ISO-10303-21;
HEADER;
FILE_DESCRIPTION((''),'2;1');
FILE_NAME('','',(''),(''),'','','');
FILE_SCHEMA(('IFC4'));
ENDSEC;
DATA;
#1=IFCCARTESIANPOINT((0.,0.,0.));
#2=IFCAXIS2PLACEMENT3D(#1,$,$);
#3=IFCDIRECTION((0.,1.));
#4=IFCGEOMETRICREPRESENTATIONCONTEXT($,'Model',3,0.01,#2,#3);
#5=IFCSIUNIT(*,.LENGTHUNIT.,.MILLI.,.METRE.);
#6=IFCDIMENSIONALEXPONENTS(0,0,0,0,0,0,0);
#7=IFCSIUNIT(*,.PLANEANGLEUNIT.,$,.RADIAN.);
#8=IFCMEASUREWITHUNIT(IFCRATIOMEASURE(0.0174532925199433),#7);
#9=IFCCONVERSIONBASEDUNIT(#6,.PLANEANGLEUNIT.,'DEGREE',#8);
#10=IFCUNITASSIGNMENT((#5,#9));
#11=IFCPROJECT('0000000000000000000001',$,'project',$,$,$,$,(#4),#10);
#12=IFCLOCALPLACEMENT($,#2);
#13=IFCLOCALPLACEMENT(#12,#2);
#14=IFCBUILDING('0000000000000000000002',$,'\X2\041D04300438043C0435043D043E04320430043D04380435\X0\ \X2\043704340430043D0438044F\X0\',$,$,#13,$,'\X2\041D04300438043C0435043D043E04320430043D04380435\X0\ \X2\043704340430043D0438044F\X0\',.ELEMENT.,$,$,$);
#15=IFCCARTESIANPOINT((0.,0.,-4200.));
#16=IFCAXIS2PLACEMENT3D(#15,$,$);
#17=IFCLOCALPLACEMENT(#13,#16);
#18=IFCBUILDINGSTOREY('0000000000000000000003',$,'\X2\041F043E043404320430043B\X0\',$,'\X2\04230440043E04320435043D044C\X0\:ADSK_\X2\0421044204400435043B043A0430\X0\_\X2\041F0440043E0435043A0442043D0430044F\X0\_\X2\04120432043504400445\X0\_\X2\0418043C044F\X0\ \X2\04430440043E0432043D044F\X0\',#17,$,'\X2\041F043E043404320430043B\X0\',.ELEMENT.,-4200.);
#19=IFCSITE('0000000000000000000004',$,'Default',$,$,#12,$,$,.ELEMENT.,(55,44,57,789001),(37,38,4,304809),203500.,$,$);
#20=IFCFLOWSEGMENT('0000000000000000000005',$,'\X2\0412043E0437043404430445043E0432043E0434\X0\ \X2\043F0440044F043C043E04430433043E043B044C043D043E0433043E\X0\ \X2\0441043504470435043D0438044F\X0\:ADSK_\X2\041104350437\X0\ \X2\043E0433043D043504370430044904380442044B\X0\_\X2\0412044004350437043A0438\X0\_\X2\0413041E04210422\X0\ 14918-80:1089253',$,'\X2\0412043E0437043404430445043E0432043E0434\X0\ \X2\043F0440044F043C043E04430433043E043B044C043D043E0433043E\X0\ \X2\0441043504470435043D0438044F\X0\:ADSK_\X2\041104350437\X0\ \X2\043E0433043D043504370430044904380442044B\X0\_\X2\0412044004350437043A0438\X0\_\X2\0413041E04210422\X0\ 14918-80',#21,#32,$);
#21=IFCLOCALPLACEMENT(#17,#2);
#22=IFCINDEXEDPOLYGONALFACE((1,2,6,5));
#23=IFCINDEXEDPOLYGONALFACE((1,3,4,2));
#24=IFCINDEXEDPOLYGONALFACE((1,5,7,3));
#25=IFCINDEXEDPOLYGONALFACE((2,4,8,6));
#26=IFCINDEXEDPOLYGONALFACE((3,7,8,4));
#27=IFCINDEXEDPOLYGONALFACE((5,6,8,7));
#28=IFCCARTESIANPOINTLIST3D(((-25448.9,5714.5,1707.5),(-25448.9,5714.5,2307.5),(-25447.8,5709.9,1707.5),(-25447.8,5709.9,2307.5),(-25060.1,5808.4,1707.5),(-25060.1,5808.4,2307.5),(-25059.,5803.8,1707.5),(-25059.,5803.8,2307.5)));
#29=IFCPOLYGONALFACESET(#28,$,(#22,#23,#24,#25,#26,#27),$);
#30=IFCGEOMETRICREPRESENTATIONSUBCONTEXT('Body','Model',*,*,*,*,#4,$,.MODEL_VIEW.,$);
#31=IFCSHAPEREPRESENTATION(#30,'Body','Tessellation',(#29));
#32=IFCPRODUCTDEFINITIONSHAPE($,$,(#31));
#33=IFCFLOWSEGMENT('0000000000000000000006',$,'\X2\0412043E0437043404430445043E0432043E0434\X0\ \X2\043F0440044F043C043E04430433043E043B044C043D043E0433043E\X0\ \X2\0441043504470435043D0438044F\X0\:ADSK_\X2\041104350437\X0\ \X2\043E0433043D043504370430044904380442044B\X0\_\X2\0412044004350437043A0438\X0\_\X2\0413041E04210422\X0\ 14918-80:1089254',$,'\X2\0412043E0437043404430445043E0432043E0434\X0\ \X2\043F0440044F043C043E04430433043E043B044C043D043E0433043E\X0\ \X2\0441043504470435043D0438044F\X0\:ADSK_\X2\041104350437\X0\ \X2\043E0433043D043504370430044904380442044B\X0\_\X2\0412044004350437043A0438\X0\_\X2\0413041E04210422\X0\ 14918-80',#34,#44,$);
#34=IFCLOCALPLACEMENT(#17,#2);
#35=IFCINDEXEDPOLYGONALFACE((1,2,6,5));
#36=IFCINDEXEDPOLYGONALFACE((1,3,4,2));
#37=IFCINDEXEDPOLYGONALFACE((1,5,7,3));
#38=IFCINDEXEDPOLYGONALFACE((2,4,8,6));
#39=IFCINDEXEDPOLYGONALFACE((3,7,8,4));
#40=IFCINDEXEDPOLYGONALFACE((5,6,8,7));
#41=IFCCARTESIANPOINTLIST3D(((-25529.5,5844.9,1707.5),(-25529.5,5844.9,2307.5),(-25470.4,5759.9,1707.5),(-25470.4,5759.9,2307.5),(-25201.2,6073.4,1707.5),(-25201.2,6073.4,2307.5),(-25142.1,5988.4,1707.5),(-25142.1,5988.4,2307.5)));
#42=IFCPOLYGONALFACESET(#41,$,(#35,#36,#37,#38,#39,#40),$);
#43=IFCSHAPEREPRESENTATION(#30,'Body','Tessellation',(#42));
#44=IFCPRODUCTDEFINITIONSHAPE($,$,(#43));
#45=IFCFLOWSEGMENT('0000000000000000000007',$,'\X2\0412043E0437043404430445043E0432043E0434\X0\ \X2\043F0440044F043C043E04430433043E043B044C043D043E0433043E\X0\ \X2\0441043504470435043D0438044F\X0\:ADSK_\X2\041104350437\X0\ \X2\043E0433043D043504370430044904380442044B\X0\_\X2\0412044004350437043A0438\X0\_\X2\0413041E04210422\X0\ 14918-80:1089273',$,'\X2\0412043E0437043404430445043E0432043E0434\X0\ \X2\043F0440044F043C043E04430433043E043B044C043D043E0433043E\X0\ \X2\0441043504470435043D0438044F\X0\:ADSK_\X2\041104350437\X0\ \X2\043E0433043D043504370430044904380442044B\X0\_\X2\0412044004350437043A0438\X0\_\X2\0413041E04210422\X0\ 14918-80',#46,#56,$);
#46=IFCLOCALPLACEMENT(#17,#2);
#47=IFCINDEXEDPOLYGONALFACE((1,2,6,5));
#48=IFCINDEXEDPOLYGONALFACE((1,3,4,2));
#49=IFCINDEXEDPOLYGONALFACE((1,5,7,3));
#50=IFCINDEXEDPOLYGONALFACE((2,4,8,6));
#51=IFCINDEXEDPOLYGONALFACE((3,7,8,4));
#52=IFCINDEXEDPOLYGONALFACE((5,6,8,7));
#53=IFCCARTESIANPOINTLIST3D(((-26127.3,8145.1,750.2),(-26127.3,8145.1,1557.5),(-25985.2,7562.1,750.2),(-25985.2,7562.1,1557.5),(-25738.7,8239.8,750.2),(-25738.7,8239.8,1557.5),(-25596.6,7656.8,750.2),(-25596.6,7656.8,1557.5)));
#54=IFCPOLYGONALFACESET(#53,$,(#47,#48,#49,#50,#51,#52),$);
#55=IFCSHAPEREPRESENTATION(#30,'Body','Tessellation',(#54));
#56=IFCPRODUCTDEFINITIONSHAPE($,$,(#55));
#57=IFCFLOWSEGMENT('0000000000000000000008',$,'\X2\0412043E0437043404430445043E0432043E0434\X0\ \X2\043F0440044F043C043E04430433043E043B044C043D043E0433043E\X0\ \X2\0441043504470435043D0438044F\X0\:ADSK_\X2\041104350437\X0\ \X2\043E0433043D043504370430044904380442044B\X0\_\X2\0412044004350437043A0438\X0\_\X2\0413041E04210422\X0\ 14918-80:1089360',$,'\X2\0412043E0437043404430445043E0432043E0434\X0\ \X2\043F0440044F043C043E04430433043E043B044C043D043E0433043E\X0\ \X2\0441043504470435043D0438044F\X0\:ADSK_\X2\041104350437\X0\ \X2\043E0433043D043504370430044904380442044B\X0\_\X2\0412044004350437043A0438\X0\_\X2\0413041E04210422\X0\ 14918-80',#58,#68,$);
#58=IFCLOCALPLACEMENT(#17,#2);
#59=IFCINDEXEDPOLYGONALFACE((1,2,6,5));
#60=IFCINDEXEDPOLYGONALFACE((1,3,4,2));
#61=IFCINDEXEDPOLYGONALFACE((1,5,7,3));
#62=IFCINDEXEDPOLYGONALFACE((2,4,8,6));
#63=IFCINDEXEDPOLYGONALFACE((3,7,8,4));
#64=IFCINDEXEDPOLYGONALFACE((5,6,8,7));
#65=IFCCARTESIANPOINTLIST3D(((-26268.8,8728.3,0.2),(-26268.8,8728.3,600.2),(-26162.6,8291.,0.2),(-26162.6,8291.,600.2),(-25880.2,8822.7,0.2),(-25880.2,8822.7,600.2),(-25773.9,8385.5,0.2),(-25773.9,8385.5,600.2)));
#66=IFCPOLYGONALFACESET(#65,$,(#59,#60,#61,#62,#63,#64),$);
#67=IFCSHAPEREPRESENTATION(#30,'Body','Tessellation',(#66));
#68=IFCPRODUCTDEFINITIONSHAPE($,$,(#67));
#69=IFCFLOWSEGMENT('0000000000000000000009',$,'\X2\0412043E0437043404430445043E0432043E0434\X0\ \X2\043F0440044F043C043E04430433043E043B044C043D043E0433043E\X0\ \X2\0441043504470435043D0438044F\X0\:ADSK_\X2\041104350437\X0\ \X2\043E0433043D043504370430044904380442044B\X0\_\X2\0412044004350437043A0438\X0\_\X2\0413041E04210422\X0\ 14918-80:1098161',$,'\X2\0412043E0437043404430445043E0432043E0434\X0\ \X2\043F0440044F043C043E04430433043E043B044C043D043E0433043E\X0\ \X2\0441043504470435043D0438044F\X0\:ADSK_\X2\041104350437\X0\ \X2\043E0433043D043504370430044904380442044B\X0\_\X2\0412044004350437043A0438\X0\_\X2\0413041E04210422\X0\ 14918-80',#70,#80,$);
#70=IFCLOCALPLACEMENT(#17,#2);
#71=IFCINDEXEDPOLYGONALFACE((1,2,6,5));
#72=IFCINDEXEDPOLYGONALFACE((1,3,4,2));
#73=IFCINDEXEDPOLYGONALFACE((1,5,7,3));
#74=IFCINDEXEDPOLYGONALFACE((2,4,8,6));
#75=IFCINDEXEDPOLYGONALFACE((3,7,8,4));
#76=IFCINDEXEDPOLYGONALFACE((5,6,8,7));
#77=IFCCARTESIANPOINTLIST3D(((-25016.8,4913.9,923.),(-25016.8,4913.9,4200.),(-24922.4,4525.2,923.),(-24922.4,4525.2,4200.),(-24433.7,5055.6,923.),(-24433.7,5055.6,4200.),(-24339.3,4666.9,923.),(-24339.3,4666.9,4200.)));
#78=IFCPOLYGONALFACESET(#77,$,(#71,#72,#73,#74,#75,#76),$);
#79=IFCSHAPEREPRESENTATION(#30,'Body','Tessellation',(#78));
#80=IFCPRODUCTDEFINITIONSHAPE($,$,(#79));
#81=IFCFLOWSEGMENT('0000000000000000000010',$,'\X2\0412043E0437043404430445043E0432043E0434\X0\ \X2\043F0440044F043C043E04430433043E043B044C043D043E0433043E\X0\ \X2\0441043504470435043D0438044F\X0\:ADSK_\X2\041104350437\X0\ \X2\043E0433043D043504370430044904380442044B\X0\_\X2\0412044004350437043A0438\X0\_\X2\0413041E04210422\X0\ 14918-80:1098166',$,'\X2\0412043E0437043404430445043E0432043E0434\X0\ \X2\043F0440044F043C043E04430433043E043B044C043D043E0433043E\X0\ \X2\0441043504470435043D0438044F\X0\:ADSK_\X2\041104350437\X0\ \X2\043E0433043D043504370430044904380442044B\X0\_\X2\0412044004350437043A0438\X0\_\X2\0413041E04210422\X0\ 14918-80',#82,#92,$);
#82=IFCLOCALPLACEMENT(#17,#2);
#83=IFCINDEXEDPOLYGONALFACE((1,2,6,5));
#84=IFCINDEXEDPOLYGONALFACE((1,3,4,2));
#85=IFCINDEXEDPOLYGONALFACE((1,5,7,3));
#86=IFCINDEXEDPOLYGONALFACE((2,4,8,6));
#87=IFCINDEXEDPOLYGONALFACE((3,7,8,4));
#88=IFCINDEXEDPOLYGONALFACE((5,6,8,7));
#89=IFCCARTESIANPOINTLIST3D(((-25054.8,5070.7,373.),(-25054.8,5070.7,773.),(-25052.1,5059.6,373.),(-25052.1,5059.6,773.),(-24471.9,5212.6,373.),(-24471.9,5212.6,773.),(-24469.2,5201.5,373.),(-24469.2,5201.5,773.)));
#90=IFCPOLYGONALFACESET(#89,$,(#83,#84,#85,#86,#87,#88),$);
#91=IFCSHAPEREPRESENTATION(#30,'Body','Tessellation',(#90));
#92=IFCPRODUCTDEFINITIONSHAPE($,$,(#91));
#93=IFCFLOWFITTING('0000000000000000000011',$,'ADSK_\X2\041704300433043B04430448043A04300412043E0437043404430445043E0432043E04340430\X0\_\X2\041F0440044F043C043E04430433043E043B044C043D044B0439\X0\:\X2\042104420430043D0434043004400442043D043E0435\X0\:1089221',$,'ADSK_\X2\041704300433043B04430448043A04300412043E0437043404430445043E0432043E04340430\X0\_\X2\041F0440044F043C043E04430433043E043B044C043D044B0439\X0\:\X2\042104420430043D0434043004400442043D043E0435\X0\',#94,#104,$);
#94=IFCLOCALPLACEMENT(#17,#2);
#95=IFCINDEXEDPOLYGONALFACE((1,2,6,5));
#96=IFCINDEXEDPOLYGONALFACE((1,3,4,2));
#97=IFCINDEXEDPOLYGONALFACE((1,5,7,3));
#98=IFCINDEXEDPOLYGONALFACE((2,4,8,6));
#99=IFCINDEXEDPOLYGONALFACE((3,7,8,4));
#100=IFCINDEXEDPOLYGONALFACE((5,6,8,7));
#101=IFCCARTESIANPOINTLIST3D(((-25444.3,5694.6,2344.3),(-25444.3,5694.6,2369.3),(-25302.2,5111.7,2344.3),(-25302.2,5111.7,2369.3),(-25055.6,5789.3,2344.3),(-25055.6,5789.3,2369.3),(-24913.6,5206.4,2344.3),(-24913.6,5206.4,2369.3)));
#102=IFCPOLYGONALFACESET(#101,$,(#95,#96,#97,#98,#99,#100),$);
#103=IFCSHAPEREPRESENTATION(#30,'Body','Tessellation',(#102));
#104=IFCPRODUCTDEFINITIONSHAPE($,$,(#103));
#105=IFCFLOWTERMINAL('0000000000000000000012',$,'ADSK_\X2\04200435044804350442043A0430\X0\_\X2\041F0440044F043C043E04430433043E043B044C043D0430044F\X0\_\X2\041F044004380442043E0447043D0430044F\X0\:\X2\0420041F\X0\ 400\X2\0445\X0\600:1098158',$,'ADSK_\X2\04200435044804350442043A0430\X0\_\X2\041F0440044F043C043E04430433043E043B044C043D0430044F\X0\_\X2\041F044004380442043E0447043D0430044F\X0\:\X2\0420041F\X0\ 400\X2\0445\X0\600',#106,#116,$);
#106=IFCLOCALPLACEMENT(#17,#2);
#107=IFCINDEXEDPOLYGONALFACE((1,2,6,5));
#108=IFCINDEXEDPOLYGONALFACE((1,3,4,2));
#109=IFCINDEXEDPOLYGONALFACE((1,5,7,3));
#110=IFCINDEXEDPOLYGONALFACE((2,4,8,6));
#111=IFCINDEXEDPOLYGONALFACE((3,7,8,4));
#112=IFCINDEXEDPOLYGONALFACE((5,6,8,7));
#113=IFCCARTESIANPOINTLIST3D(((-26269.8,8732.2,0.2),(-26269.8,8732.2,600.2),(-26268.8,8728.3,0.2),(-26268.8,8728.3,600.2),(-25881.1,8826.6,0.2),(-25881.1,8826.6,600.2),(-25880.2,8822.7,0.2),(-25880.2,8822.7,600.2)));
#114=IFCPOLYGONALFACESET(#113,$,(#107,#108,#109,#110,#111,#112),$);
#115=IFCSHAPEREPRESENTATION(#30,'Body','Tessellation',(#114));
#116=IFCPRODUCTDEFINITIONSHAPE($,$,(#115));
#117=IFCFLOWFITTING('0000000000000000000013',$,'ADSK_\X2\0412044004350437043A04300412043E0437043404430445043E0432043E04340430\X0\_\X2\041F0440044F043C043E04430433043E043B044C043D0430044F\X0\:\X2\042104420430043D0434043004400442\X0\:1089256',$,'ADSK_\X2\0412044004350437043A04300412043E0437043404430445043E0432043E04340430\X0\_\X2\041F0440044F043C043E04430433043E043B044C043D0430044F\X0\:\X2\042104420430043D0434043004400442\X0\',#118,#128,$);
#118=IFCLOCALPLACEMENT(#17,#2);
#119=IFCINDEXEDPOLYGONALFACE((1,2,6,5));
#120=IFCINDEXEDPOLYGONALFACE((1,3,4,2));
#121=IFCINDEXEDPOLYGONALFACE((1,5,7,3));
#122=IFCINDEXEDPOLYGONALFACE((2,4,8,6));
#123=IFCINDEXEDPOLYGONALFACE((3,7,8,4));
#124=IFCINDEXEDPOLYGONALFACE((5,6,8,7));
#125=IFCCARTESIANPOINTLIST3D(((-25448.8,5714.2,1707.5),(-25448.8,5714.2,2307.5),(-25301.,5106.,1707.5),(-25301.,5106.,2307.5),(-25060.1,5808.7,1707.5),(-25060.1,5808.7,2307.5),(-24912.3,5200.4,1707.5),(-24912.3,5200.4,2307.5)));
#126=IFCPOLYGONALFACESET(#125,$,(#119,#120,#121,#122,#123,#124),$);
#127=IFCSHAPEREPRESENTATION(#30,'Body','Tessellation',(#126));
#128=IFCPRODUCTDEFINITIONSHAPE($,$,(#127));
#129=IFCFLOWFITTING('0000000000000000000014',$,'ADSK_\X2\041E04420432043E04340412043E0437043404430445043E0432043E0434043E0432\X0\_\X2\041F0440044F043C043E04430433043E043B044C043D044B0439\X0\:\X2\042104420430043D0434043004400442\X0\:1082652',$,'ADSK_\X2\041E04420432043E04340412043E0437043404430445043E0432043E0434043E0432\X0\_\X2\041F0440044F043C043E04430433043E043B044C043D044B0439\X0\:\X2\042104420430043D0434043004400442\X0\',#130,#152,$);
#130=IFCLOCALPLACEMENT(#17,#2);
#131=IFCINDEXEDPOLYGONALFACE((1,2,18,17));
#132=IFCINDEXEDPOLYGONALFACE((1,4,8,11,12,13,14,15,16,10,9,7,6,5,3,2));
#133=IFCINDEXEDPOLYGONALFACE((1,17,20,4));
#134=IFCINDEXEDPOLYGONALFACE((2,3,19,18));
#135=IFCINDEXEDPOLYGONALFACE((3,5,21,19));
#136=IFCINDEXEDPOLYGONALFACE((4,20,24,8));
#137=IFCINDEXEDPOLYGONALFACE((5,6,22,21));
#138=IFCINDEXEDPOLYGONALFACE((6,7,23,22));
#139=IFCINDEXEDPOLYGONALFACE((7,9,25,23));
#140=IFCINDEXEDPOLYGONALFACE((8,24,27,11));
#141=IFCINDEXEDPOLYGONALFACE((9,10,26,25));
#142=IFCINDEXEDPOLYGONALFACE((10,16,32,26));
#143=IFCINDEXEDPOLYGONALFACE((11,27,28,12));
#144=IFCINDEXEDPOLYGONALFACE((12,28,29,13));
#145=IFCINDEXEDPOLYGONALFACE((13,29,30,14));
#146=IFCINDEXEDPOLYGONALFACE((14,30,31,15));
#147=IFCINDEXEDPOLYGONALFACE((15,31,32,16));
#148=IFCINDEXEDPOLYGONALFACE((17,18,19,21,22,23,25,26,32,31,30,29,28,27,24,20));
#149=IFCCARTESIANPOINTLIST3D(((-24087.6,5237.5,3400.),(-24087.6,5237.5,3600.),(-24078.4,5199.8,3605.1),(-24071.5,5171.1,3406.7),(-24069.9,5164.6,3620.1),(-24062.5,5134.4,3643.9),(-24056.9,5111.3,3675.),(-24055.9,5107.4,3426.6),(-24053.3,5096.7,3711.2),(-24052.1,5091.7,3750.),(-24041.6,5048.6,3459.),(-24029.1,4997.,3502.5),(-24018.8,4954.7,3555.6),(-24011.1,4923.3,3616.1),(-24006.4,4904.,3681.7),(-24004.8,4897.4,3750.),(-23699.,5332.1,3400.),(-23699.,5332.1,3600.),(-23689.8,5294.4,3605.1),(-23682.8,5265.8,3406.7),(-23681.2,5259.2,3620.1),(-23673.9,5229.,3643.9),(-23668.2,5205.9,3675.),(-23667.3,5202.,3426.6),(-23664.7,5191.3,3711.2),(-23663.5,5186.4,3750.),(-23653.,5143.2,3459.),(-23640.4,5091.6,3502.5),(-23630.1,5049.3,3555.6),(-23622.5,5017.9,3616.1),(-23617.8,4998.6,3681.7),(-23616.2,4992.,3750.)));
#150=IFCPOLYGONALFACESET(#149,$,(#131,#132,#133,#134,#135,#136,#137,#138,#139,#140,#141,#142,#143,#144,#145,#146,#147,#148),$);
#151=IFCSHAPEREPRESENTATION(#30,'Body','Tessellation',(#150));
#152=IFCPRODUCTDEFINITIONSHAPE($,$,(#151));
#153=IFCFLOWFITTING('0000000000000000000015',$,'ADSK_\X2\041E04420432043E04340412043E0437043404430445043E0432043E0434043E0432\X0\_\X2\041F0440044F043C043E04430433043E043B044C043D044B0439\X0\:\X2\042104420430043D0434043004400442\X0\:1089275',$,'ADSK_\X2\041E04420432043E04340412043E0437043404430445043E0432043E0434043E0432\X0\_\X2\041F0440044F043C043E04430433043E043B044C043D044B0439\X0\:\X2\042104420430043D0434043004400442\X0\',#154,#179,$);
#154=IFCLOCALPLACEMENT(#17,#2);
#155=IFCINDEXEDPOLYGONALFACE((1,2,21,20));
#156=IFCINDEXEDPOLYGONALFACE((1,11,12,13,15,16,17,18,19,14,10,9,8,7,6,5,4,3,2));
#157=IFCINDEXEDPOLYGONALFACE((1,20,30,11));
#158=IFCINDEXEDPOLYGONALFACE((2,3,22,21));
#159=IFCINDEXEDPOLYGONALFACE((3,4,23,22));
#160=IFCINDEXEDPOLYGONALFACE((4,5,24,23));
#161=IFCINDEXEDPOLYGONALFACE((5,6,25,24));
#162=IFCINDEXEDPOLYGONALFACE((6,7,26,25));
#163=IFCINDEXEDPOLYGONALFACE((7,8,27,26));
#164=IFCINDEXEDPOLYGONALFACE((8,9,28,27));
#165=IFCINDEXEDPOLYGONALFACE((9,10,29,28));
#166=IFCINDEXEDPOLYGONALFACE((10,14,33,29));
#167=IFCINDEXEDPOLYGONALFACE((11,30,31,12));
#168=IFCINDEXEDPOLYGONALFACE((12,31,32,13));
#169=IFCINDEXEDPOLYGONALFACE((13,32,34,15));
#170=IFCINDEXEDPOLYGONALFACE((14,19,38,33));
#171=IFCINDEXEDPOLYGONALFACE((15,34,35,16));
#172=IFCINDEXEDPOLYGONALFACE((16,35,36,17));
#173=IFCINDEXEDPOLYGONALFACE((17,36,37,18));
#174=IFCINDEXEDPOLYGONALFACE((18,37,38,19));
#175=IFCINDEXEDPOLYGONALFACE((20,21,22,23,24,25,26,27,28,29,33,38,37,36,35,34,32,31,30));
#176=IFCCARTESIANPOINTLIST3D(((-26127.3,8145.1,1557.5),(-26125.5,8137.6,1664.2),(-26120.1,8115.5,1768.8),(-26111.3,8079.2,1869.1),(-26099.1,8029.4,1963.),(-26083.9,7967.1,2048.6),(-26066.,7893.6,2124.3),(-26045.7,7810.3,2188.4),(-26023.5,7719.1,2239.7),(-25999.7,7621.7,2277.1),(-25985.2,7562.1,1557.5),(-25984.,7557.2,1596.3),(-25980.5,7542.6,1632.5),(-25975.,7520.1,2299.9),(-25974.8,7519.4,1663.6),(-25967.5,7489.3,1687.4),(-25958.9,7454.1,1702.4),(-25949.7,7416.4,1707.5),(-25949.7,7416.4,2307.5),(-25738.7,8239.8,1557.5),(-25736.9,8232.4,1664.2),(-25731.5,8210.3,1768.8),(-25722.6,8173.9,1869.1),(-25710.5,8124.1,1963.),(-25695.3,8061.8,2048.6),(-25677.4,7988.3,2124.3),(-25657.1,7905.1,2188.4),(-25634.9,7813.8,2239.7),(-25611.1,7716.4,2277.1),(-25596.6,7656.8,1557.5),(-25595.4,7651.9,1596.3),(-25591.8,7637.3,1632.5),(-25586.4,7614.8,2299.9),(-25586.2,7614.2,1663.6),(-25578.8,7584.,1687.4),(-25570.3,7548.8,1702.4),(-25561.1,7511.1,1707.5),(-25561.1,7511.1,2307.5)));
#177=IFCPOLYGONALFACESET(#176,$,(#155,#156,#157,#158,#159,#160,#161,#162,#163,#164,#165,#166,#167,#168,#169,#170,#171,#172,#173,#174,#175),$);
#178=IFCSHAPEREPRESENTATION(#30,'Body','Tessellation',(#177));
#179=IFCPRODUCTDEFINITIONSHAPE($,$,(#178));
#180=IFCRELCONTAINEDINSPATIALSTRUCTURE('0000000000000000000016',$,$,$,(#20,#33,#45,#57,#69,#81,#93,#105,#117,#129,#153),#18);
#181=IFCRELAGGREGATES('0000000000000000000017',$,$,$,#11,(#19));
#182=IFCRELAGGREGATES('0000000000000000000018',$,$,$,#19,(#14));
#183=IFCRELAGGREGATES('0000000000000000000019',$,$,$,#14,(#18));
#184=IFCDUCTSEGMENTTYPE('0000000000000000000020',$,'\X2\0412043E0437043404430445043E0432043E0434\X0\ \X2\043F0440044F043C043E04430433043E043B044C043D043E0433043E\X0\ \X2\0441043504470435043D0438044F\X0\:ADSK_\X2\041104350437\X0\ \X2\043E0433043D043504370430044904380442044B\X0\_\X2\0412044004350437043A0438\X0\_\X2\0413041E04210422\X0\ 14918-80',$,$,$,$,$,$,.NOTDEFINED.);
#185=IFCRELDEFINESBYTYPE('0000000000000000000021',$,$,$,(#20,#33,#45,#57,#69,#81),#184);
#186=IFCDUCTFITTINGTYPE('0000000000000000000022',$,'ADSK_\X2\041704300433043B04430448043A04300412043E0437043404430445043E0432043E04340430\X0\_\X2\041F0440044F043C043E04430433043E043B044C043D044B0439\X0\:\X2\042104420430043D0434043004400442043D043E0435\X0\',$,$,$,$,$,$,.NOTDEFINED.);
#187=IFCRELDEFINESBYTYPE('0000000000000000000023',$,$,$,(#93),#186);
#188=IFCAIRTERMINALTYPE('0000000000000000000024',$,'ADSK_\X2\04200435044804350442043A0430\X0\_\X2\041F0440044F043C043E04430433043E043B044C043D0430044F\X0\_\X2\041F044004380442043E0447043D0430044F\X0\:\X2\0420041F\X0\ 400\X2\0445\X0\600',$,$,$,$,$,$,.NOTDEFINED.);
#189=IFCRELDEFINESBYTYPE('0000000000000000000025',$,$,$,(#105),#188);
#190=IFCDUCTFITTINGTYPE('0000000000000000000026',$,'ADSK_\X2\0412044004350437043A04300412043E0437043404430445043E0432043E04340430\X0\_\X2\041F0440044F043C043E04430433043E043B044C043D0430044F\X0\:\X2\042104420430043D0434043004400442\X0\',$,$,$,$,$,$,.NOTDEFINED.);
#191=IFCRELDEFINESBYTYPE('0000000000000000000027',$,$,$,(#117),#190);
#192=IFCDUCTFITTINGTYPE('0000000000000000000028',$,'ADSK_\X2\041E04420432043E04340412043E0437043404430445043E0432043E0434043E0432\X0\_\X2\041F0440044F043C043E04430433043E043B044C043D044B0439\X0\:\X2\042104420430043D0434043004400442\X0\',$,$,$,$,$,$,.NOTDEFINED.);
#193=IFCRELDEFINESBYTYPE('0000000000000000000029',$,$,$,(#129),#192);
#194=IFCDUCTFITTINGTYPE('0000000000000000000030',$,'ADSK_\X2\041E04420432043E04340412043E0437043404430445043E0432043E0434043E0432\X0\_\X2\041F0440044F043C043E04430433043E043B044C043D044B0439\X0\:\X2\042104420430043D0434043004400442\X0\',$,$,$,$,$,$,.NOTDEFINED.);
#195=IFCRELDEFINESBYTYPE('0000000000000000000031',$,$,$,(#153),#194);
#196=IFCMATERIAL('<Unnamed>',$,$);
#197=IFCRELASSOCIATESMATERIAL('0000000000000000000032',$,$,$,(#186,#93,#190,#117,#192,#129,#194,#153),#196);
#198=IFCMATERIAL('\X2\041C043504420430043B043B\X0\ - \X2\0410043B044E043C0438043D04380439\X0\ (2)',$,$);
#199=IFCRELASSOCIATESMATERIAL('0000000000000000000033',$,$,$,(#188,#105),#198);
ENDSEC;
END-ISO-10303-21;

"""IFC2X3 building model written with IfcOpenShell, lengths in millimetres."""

from ifc_helpers import new_model, entity, si_unit, converted_unit, direction, frame, frame_2d, origin, origin_2d_with_axis, place, context, subcontext, project, spatial, polyline, circle_curve, parameter, trimmed, segment, composite_curve, rectangle, outline, extrude, source, transform, mapped, material, type_object, type_shapes, element, save


model = new_model("IFC2X3")

# Units and contexts
model_context = context("Model", 3, precision=0.01, world=origin(), true_north=direction((0.0, 1.0)))
body_context = subcontext(model_context, "Body", "Model", "MODEL_VIEW")
ifc_project = project(units=[si_unit("LENGTHUNIT", "METRE", prefix="MILLI"), converted_unit("PLANEANGLEUNIT", "DEGREE", entity("IfcRatioMeasure", 0.0174532925199433), si_unit("PLANEANGLEUNIT", "RADIAN"), dimensions=[0, 0, 0, 0, 0, 0, 0])], contexts=[model_context])

# Site, building, storey
site_placement = place(None, origin())
site = spatial("IfcSite", under=ifc_project, at=site_placement, Name="Default", CompositionType="ELEMENT", RefLatitude=(55, 44, 57, 789001), RefLongitude=(37, 38, 4, 304809), RefElevation=203500.0)
building_placement = place(site_placement, origin())
building = spatial("IfcBuilding", under=site, at=building_placement, Name="Наименование здания", LongName="Наименование здания", CompositionType="ELEMENT")
storey_placement = place(building_placement, frame((0.0, 0.0, -4200.0)))
storey = spatial("IfcBuildingStorey", under=building, at=storey_placement, Name="Подвал", ObjectType="Уровень:ADSK_Стрелка_Проектная_Вверх_Имя уровня", LongName="Подвал", CompositionType="ELEMENT", Elevation=-4200.0)

# Flow segments
duct_segment_type_1 = type_object("IfcDuctSegmentType", Name="Воздуховод прямоугольного сечения:ADSK_Без огнезащиты_Врезки_ГОСТ 14918-80", PredefinedType="NOTDEFINED")
flow_segment_1_placement = place(storey_placement, frame((-25448.9, 5709.9, 1707.5)))
element("IfcFlowSegment", 1, at=flow_segment_1_placement, inside=storey, type_object=duct_segment_type_1, Name="Воздуховод прямоугольного сечения:ADSK_Без огнезащиты_Врезки_ГОСТ 14918-80:1089253", ObjectType="Воздуховод прямоугольного сечения:ADSK_Без огнезащиты_Врезки_ГОСТ 14918-80", context=body_context, shape_type="SweptSolid", body=[
    extrude(rectangle(XDim=4.8, YDim=400.0, at=origin_2d_with_axis()), frame((195.0, 49.3, 0.0), z_axis=(0.0, 0.0, 1.0), x_axis=(0.234768, -0.972051, 0.0)), (0.0, 0.0, 1.0), 600.0),
])
flow_segment_2_placement = place(storey_placement, frame((-25529.5, 5759.9, 1707.5)))
element("IfcFlowSegment", 2, at=flow_segment_2_placement, inside=storey, type_object=duct_segment_type_1, Name="Воздуховод прямоугольного сечения:ADSK_Без огнезащиты_Врезки_ГОСТ 14918-80:1089254", ObjectType="Воздуховод прямоугольного сечения:ADSK_Без огнезащиты_Врезки_ГОСТ 14918-80", context=body_context, shape_type="SweptSolid", body=[
    extrude(rectangle(XDim=103.6, YDim=400.0, at=origin_2d_with_axis()), frame((193.7, 156.8, 0.0), z_axis=(0.0, 0.0, 1.0), x_axis=(-0.571319, 0.820728, 0.0)), (0.0, 0.0, 1.0), 600.0),
])
flow_segment_3_placement = place(storey_placement, frame((-26127.3, 7562.1, 750.2)))
element("IfcFlowSegment", 3, at=flow_segment_3_placement, inside=storey, type_object=duct_segment_type_1, Name="Воздуховод прямоугольного сечения:ADSK_Без огнезащиты_Врезки_ГОСТ 14918-80:1089273", ObjectType="Воздуховод прямоугольного сечения:ADSK_Без огнезащиты_Врезки_ГОСТ 14918-80", context=body_context, shape_type="SweptSolid", body=[
    extrude(rectangle(XDim=400.0, YDim=600.0, at=origin_2d_with_axis()), frame((265.4, 338.8, 0.0), z_axis=(0.0, 0.0, 1.0), x_axis=(-0.971553, -0.236821, 0.0)), (0.0, 0.0, 1.0), 807.3),
])
flow_segment_4_placement = place(storey_placement, frame((-26268.8, 8291.0, 0.2)))
element("IfcFlowSegment", 4, at=flow_segment_4_placement, inside=storey, type_object=duct_segment_type_1, Name="Воздуховод прямоугольного сечения:ADSK_Без огнезащиты_Врезки_ГОСТ 14918-80:1089360", ObjectType="Воздуховод прямоугольного сечения:ADSK_Без огнезащиты_Врезки_ГОСТ 14918-80", context=body_context, shape_type="SweptSolid", body=[
    extrude(rectangle(XDim=450.0, YDim=400.0, at=origin_2d_with_axis()), frame((247.5, 265.9, 0.0), z_axis=(0.0, 0.0, 1.0), x_axis=(-0.23616, 0.971714, 0.0)), (0.0, 0.0, 1.0), 600.0),
])
flow_segment_5_placement = place(storey_placement, frame((-25016.8, 4525.2, 923.0)))
element("IfcFlowSegment", 5, at=flow_segment_5_placement, inside=storey, type_object=duct_segment_type_1, Name="Воздуховод прямоугольного сечения:ADSK_Без огнезащиты_Врезки_ГОСТ 14918-80:1098161", ObjectType="Воздуховод прямоугольного сечения:ADSK_Без огнезащиты_Врезки_ГОСТ 14918-80", context=body_context, shape_type="SweptSolid", body=[
    extrude(rectangle(XDim=600.0, YDim=400.0, at=origin_2d_with_axis()), frame((338.7, 265.2, 0.0), z_axis=(0.0, 0.0, 1.0), x_axis=(0.971743, 0.23604, 0.0)), (0.0, 0.0, 1.0), 3277.0),
])
flow_segment_6_placement = place(storey_placement, frame((-25054.8, 5059.6, 373.0)))
element("IfcFlowSegment", 6, at=flow_segment_6_placement, inside=storey, type_object=duct_segment_type_1, Name="Воздуховод прямоугольного сечения:ADSK_Без огнезащиты_Врезки_ГОСТ 14918-80:1098166", ObjectType="Воздуховод прямоугольного сечения:ADSK_Без огнезащиты_Врезки_ГОСТ 14918-80", context=body_context, shape_type="SweptSolid", body=[
    extrude(rectangle(XDim=11.4, YDim=600.0, at=origin_2d_with_axis()), frame((292.8, 76.5, 0.0), z_axis=(0.0, 0.0, 1.0), x_axis=(0.236532, -0.971624, 0.0)), (0.0, 0.0, 1.0), 400.0),
])

# Flow fitting
ifc_material_1 = material(Name="<Unnamed>")
duct_fitting_type_1 = type_object("IfcDuctFittingType", Name="ADSK_ЗаглушкаВоздуховода_Прямоугольный:Стандартное", PredefinedType="NOTDEFINED", material=ifc_material_1)
shared_shape_1 = source(origin(), body_context, "Body", "SweptSolid", [
    extrude(rectangle(XDim=25.0, YDim=400.0, at=origin_2d_with_axis()), frame((12.5, 0.0, -300.0)), (0.0, 0.0, 1.0), 600.0),
])
type_shapes(duct_fitting_type_1, [shared_shape_1])
flow_fitting_1_placement = place(storey_placement, frame((-25178.9, 5450.5, 2344.3), z_axis=(0.236821, -0.971553, 0.0), x_axis=(0.0, 0.0, 1.0)))
element("IfcFlowFitting", 7, at=flow_fitting_1_placement, inside=storey, type_object=duct_fitting_type_1, material=ifc_material_1, Name="ADSK_ЗаглушкаВоздуховода_Прямоугольный:Стандартное:1089221", ObjectType="ADSK_ЗаглушкаВоздуховода_Прямоугольный:Стандартное", context=body_context, shape_type="MappedRepresentation", body=[
    mapped(shared_shape_1, transform((0.0, 0.0, 0.0), scale=1.0)),
])

# Flow terminal
ifc_material_2 = material(Name="Металл - Алюминий (2)")
air_terminal_type = type_object("IfcAirTerminalType", Name="ADSK_Решетка_Прямоугольная_Приточная:РП 400х600", PredefinedType="NOTDEFINED", material=ifc_material_2)
shared_shape_2 = source(origin(), body_context, "Body", "SweptSolid", [
    extrude(rectangle(XDim=4.0, YDim=400.0, at=origin_2d_with_axis()), frame((0.0, -2.0, -300.0), z_axis=(0.0, 0.0, 1.0), x_axis=(0.0, 1.0, 0.0)), (0.0, 0.0, 1.0), 600.0),
])
type_shapes(air_terminal_type, [shared_shape_2])
flow_terminal_placement = place(storey_placement, frame((-26074.5, 8775.5, 300.2), z_axis=(0.0, 0.0, 1.0), x_axis=(-0.971714, -0.23616, 0.0)))
element("IfcFlowTerminal", 8, at=flow_terminal_placement, inside=storey, type_object=air_terminal_type, material=ifc_material_2, Name="ADSK_Решетка_Прямоугольная_Приточная:РП 400х600:1098158", ObjectType="ADSK_Решетка_Прямоугольная_Приточная:РП 400х600", context=body_context, shape_type="MappedRepresentation", body=[
    mapped(shared_shape_2, transform((0.0, 0.0, 0.0), scale=1.0)),
])

# Flow fittings
duct_fitting_type_2 = type_object("IfcDuctFittingType", Name="ADSK_ВрезкаВоздуховода_Прямоугольная:Стандарт", PredefinedType="NOTDEFINED", material=ifc_material_1)
shared_shape_3 = source(origin(), body_context, "Body", "SweptSolid", [
    extrude(rectangle(XDim=626.0, YDim=600.0, at=origin_2d_with_axis()), frame((-293.0, 0.0, -200.0)), (0.0, 0.0, 1.0), 400.0),
])
type_shapes(duct_fitting_type_2, [shared_shape_3])
flow_fitting_2_placement = place(storey_placement, frame((-25249.8, 5742.0, 2007.5), z_axis=(0.971714, 0.23616, 0.0), x_axis=(-0.23616, 0.971714, 0.0)))
element("IfcFlowFitting", 9, at=flow_fitting_2_placement, inside=storey, type_object=duct_fitting_type_2, material=ifc_material_1, Name="ADSK_ВрезкаВоздуховода_Прямоугольная:Стандарт:1089256", ObjectType="ADSK_ВрезкаВоздуховода_Прямоугольная:Стандарт", context=body_context, shape_type="MappedRepresentation", body=[
    mapped(shared_shape_3, transform((0.0, 0.0, 0.0), scale=1.0)),
])
duct_fitting_type_3 = type_object("IfcDuctFittingType", Name="ADSK_ОтводВоздуховодов_Прямоугольный:Стандарт", PredefinedType="NOTDEFINED", material=ifc_material_1)
shared_shape_4 = source(origin(), body_context, "Body", "SweptSolid", [
    extrude(outline(composite_curve([segment(polyline([(-225.0, -125.0), (-25.0, -125.0)]), True, "CONTINUOUS"), segment(trimmed(circle_curve(frame_2d((125.0, -125.0), x_axis=(0.0, 1.0)), 150.0), [parameter(0.0)], [parameter(90.0)], True, "PARAMETER"), False, "CONTINUOUS"), segment(polyline([(125.0, 25.0), (125.0, 225.0)]), True, "CONTINUOUS"), segment(trimmed(circle_curve(frame_2d((125.0, -125.0), x_axis=(0.0, 1.0)), 350.0), [parameter(0.0)], [parameter(90.0)], True, "PARAMETER"), True, "CONTINUOUS")], self_intersect=False)), frame((-125.0, 125.0, -200.0), z_axis=(0.0, 0.0, 1.0), x_axis=(-1.0, 0.0, 0.0)), (0.0, 0.0, 1.0), 400.0),
])
type_shapes(duct_fitting_type_3, [shared_shape_4])
flow_fitting_3_placement = place(storey_placement, frame((-23834.2, 5041.9, 3500.0), z_axis=(-0.971627, -0.236517, 0.0), x_axis=(0.236517, -0.971627, 0.0)))
element("IfcFlowFitting", 10, at=flow_fitting_3_placement, inside=storey, type_object=duct_fitting_type_3, material=ifc_material_1, Name="ADSK_ОтводВоздуховодов_Прямоугольный:Стандарт:1082652", ObjectType="ADSK_ОтводВоздуховодов_Прямоугольный:Стандарт", context=body_context, shape_type="MappedRepresentation", body=[
    mapped(shared_shape_4, transform((0.0, 0.0, 0.0), scale=1.0)),
])
duct_fitting_type_4 = type_object("IfcDuctFittingType", Name="ADSK_ОтводВоздуховодов_Прямоугольный:Стандарт", PredefinedType="NOTDEFINED", material=ifc_material_1)
shared_shape_5 = source(origin(), body_context, "Body", "SweptSolid", [
    extrude(outline(composite_curve([segment(polyline([(-525.0, -225.0), (75.0, -225.0)]), True, "CONTINUOUS"), segment(trimmed(circle_curve(frame_2d((225.0, -225.0), x_axis=(0.0, 1.0)), 150.0), [parameter(0.0)], [parameter(90.0)], True, "PARAMETER"), False, "CONTINUOUS"), segment(polyline([(225.0, -75.0), (225.0, 525.0)]), True, "CONTINUOUS"), segment(trimmed(circle_curve(frame_2d((225.0, -225.0), x_axis=(0.0, 1.0)), 750.0), [parameter(0.0)], [parameter(90.0)], True, "PARAMETER"), True, "CONTINUOUS")], self_intersect=False)), frame((-225.0, 225.0, -200.0), z_axis=(0.0, 0.0, 1.0), x_axis=(-1.0, 0.0, 0.0)), (0.0, 0.0, 1.0), 400.0),
])
type_shapes(duct_fitting_type_4, [shared_shape_5])
for number, where, z_axis, x_axis, name in (
    (11, (-25862.0, 7900.9, 2007.5), (-0.971553, -0.236821, 0.0), (-0.236821, 0.971553, 0.0), "ADSK_ОтводВоздуховодов_Прямоугольный:Стандарт:1089275"),
):
    element("IfcFlowFitting", number, at=place(storey_placement, frame(where, z_axis=z_axis, x_axis=x_axis)), inside=storey, type_object=duct_fitting_type_4, material=ifc_material_1, Name=name, ObjectType="ADSK_ОтводВоздуховодов_Прямоугольный:Стандарт", context=body_context, shape_type="MappedRepresentation", body=[
        mapped(shared_shape_5, transform((0.0, 0.0, 0.0), scale=1.0)),
    ])

save(model, "model.ifc")
